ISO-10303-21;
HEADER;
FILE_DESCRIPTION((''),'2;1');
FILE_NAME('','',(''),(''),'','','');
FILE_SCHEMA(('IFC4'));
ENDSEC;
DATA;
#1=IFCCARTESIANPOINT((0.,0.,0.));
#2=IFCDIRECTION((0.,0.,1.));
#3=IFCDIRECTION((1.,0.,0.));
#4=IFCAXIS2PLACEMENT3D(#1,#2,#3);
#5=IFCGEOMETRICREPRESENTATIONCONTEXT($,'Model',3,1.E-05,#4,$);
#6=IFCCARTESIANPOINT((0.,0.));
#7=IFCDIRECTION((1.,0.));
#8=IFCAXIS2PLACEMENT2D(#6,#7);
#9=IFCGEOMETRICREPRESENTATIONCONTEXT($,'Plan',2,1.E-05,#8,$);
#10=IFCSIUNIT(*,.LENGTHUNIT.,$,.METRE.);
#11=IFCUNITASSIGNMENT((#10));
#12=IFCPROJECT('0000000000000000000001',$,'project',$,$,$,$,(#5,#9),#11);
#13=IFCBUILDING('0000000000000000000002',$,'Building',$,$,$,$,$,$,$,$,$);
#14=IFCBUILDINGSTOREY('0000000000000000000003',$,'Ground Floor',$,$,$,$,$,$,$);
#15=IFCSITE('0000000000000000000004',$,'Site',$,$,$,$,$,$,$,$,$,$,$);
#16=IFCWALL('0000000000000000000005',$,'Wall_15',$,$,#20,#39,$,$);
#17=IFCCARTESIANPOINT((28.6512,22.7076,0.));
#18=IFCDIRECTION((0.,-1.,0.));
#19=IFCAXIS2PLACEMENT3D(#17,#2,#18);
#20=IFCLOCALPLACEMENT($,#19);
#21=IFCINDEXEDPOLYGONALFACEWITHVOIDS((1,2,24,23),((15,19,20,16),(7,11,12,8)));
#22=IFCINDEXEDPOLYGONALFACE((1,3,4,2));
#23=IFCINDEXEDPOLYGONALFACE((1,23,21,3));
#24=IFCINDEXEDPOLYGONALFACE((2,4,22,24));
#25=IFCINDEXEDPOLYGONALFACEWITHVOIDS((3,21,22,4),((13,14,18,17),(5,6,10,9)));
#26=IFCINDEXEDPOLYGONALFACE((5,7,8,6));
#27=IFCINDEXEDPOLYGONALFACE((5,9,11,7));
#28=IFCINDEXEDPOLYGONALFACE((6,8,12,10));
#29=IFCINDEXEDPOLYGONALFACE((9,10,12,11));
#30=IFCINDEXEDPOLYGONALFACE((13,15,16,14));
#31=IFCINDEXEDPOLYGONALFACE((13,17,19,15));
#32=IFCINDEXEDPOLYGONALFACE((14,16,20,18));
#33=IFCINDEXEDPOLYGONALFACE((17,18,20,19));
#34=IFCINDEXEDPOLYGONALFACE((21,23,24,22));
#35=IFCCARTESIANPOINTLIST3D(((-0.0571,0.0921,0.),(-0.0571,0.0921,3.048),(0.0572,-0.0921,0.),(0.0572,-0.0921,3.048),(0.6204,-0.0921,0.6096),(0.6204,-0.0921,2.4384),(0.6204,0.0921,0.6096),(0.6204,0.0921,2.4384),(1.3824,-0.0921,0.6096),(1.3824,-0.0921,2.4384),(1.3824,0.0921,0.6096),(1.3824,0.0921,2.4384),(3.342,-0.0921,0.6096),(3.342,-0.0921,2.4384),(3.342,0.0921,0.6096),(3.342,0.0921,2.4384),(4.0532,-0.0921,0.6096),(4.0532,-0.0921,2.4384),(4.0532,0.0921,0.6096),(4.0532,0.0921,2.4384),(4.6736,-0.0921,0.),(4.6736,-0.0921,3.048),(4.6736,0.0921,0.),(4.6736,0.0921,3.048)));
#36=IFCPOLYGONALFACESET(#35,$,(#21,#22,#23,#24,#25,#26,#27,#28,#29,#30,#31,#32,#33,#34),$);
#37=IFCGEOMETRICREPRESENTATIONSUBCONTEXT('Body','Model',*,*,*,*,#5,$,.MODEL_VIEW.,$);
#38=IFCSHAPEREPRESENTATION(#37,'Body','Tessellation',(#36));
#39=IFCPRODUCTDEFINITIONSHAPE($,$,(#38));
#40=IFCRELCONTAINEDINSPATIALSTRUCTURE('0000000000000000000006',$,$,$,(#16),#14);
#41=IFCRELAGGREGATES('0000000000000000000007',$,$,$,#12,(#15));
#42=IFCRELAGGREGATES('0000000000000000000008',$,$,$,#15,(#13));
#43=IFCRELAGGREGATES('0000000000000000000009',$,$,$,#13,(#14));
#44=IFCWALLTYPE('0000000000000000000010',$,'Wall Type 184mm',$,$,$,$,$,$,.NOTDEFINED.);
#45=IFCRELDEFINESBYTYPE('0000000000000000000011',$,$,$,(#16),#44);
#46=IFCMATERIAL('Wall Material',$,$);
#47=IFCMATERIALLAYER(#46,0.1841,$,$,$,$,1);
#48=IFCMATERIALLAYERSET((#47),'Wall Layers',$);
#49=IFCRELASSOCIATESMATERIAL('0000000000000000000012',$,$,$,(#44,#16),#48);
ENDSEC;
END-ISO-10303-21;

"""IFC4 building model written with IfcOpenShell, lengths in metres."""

from ifc_helpers import new_model, si_unit, frame, origin_with_axes, origin_2d_with_axis, place, context, subcontext, project, spatial, line, indexed_curve, rectangle, outline, extrude, material, layer, layer_set, layer_usage, type_object, element, save


model = new_model("IFC4")

# Units and contexts
model_context = context("Model", 3, precision=1e-05, world=origin_with_axes())
plan_context = context("Plan", 2, precision=1e-05, world=origin_2d_with_axis())
body_context = subcontext(model_context, "Body", "Model", "MODEL_VIEW")
ifc_project = project(units=[si_unit("LENGTHUNIT", "METRE")], contexts=[model_context, plan_context])

# Site, building, storey
site = spatial("IfcSite", under=ifc_project, Name="Site")
building = spatial("IfcBuilding", under=site, Name="Building")
storey = spatial("IfcBuildingStorey", under=building, Name="Ground Floor")

# Shared definitions
ifc_material_1 = material(Name="Wall Material")
ifc_layer_1 = layer(ifc_material_1, 0.1841, Priority=1)
ifc_layer_set_1 = layer_set([ifc_layer_1], Name="Wall Layers")
wall_type_1 = type_object("IfcWallType", Name="Wall Type 184mm", PredefinedType="NOTDEFINED", material=ifc_layer_set_1)

# Wall, openings
ifc_layer_usage_1 = layer_usage(ifc_layer_set_1, "AXIS2", "POSITIVE", -0.0921)
wall_1_placement = place(None, frame((28.6512, 22.7076, 0.0), z_axis=(0.0, 0.0, 1.0), x_axis=(0.0, -1.0, 0.0)))
wall_1 = element("IfcWall", 1, at=wall_1_placement, inside=storey, type_object=wall_type_1, material=ifc_layer_usage_1, Name="Wall_15", context=body_context, shape_type="SweptSolid", body=[
    extrude(outline(indexed_curve([(0.0571, -0.0921), (-0.0571, 0.0921), (4.6736, 0.0921), (4.6736, -0.0921)], segments=[line(1, 2, 3, 4, 1)])), origin_with_axes(), (0.0, 0.0, 1.0), 3.048),
])
opening_1_placement = place(wall_1_placement, frame((1.0014, 0.0, 0.6096), z_axis=(0.0, 0.0, 1.0), x_axis=(1.0, 0.0, 0.0)))
element("IfcOpeningElement", 2, at=opening_1_placement, cuts=wall_1, context=body_context, shape_type="SweptSolid", body=[
    extrude(rectangle(XDim=0.762, YDim=0.5524), None, (0.0, 0.0, 1.0), 1.8288),
])
opening_2_placement = place(wall_1_placement, frame((3.6976, 0.0, 0.6096), z_axis=(0.0, 0.0, 1.0), x_axis=(1.0, 0.0, 0.0)))
element("IfcOpeningElement", 3, at=opening_2_placement, cuts=wall_1, context=body_context, shape_type="SweptSolid", body=[
    extrude(rectangle(XDim=0.7112, YDim=0.5524), None, (0.0, 0.0, 1.0), 1.8288),
])

save(model, "model.ifc")
